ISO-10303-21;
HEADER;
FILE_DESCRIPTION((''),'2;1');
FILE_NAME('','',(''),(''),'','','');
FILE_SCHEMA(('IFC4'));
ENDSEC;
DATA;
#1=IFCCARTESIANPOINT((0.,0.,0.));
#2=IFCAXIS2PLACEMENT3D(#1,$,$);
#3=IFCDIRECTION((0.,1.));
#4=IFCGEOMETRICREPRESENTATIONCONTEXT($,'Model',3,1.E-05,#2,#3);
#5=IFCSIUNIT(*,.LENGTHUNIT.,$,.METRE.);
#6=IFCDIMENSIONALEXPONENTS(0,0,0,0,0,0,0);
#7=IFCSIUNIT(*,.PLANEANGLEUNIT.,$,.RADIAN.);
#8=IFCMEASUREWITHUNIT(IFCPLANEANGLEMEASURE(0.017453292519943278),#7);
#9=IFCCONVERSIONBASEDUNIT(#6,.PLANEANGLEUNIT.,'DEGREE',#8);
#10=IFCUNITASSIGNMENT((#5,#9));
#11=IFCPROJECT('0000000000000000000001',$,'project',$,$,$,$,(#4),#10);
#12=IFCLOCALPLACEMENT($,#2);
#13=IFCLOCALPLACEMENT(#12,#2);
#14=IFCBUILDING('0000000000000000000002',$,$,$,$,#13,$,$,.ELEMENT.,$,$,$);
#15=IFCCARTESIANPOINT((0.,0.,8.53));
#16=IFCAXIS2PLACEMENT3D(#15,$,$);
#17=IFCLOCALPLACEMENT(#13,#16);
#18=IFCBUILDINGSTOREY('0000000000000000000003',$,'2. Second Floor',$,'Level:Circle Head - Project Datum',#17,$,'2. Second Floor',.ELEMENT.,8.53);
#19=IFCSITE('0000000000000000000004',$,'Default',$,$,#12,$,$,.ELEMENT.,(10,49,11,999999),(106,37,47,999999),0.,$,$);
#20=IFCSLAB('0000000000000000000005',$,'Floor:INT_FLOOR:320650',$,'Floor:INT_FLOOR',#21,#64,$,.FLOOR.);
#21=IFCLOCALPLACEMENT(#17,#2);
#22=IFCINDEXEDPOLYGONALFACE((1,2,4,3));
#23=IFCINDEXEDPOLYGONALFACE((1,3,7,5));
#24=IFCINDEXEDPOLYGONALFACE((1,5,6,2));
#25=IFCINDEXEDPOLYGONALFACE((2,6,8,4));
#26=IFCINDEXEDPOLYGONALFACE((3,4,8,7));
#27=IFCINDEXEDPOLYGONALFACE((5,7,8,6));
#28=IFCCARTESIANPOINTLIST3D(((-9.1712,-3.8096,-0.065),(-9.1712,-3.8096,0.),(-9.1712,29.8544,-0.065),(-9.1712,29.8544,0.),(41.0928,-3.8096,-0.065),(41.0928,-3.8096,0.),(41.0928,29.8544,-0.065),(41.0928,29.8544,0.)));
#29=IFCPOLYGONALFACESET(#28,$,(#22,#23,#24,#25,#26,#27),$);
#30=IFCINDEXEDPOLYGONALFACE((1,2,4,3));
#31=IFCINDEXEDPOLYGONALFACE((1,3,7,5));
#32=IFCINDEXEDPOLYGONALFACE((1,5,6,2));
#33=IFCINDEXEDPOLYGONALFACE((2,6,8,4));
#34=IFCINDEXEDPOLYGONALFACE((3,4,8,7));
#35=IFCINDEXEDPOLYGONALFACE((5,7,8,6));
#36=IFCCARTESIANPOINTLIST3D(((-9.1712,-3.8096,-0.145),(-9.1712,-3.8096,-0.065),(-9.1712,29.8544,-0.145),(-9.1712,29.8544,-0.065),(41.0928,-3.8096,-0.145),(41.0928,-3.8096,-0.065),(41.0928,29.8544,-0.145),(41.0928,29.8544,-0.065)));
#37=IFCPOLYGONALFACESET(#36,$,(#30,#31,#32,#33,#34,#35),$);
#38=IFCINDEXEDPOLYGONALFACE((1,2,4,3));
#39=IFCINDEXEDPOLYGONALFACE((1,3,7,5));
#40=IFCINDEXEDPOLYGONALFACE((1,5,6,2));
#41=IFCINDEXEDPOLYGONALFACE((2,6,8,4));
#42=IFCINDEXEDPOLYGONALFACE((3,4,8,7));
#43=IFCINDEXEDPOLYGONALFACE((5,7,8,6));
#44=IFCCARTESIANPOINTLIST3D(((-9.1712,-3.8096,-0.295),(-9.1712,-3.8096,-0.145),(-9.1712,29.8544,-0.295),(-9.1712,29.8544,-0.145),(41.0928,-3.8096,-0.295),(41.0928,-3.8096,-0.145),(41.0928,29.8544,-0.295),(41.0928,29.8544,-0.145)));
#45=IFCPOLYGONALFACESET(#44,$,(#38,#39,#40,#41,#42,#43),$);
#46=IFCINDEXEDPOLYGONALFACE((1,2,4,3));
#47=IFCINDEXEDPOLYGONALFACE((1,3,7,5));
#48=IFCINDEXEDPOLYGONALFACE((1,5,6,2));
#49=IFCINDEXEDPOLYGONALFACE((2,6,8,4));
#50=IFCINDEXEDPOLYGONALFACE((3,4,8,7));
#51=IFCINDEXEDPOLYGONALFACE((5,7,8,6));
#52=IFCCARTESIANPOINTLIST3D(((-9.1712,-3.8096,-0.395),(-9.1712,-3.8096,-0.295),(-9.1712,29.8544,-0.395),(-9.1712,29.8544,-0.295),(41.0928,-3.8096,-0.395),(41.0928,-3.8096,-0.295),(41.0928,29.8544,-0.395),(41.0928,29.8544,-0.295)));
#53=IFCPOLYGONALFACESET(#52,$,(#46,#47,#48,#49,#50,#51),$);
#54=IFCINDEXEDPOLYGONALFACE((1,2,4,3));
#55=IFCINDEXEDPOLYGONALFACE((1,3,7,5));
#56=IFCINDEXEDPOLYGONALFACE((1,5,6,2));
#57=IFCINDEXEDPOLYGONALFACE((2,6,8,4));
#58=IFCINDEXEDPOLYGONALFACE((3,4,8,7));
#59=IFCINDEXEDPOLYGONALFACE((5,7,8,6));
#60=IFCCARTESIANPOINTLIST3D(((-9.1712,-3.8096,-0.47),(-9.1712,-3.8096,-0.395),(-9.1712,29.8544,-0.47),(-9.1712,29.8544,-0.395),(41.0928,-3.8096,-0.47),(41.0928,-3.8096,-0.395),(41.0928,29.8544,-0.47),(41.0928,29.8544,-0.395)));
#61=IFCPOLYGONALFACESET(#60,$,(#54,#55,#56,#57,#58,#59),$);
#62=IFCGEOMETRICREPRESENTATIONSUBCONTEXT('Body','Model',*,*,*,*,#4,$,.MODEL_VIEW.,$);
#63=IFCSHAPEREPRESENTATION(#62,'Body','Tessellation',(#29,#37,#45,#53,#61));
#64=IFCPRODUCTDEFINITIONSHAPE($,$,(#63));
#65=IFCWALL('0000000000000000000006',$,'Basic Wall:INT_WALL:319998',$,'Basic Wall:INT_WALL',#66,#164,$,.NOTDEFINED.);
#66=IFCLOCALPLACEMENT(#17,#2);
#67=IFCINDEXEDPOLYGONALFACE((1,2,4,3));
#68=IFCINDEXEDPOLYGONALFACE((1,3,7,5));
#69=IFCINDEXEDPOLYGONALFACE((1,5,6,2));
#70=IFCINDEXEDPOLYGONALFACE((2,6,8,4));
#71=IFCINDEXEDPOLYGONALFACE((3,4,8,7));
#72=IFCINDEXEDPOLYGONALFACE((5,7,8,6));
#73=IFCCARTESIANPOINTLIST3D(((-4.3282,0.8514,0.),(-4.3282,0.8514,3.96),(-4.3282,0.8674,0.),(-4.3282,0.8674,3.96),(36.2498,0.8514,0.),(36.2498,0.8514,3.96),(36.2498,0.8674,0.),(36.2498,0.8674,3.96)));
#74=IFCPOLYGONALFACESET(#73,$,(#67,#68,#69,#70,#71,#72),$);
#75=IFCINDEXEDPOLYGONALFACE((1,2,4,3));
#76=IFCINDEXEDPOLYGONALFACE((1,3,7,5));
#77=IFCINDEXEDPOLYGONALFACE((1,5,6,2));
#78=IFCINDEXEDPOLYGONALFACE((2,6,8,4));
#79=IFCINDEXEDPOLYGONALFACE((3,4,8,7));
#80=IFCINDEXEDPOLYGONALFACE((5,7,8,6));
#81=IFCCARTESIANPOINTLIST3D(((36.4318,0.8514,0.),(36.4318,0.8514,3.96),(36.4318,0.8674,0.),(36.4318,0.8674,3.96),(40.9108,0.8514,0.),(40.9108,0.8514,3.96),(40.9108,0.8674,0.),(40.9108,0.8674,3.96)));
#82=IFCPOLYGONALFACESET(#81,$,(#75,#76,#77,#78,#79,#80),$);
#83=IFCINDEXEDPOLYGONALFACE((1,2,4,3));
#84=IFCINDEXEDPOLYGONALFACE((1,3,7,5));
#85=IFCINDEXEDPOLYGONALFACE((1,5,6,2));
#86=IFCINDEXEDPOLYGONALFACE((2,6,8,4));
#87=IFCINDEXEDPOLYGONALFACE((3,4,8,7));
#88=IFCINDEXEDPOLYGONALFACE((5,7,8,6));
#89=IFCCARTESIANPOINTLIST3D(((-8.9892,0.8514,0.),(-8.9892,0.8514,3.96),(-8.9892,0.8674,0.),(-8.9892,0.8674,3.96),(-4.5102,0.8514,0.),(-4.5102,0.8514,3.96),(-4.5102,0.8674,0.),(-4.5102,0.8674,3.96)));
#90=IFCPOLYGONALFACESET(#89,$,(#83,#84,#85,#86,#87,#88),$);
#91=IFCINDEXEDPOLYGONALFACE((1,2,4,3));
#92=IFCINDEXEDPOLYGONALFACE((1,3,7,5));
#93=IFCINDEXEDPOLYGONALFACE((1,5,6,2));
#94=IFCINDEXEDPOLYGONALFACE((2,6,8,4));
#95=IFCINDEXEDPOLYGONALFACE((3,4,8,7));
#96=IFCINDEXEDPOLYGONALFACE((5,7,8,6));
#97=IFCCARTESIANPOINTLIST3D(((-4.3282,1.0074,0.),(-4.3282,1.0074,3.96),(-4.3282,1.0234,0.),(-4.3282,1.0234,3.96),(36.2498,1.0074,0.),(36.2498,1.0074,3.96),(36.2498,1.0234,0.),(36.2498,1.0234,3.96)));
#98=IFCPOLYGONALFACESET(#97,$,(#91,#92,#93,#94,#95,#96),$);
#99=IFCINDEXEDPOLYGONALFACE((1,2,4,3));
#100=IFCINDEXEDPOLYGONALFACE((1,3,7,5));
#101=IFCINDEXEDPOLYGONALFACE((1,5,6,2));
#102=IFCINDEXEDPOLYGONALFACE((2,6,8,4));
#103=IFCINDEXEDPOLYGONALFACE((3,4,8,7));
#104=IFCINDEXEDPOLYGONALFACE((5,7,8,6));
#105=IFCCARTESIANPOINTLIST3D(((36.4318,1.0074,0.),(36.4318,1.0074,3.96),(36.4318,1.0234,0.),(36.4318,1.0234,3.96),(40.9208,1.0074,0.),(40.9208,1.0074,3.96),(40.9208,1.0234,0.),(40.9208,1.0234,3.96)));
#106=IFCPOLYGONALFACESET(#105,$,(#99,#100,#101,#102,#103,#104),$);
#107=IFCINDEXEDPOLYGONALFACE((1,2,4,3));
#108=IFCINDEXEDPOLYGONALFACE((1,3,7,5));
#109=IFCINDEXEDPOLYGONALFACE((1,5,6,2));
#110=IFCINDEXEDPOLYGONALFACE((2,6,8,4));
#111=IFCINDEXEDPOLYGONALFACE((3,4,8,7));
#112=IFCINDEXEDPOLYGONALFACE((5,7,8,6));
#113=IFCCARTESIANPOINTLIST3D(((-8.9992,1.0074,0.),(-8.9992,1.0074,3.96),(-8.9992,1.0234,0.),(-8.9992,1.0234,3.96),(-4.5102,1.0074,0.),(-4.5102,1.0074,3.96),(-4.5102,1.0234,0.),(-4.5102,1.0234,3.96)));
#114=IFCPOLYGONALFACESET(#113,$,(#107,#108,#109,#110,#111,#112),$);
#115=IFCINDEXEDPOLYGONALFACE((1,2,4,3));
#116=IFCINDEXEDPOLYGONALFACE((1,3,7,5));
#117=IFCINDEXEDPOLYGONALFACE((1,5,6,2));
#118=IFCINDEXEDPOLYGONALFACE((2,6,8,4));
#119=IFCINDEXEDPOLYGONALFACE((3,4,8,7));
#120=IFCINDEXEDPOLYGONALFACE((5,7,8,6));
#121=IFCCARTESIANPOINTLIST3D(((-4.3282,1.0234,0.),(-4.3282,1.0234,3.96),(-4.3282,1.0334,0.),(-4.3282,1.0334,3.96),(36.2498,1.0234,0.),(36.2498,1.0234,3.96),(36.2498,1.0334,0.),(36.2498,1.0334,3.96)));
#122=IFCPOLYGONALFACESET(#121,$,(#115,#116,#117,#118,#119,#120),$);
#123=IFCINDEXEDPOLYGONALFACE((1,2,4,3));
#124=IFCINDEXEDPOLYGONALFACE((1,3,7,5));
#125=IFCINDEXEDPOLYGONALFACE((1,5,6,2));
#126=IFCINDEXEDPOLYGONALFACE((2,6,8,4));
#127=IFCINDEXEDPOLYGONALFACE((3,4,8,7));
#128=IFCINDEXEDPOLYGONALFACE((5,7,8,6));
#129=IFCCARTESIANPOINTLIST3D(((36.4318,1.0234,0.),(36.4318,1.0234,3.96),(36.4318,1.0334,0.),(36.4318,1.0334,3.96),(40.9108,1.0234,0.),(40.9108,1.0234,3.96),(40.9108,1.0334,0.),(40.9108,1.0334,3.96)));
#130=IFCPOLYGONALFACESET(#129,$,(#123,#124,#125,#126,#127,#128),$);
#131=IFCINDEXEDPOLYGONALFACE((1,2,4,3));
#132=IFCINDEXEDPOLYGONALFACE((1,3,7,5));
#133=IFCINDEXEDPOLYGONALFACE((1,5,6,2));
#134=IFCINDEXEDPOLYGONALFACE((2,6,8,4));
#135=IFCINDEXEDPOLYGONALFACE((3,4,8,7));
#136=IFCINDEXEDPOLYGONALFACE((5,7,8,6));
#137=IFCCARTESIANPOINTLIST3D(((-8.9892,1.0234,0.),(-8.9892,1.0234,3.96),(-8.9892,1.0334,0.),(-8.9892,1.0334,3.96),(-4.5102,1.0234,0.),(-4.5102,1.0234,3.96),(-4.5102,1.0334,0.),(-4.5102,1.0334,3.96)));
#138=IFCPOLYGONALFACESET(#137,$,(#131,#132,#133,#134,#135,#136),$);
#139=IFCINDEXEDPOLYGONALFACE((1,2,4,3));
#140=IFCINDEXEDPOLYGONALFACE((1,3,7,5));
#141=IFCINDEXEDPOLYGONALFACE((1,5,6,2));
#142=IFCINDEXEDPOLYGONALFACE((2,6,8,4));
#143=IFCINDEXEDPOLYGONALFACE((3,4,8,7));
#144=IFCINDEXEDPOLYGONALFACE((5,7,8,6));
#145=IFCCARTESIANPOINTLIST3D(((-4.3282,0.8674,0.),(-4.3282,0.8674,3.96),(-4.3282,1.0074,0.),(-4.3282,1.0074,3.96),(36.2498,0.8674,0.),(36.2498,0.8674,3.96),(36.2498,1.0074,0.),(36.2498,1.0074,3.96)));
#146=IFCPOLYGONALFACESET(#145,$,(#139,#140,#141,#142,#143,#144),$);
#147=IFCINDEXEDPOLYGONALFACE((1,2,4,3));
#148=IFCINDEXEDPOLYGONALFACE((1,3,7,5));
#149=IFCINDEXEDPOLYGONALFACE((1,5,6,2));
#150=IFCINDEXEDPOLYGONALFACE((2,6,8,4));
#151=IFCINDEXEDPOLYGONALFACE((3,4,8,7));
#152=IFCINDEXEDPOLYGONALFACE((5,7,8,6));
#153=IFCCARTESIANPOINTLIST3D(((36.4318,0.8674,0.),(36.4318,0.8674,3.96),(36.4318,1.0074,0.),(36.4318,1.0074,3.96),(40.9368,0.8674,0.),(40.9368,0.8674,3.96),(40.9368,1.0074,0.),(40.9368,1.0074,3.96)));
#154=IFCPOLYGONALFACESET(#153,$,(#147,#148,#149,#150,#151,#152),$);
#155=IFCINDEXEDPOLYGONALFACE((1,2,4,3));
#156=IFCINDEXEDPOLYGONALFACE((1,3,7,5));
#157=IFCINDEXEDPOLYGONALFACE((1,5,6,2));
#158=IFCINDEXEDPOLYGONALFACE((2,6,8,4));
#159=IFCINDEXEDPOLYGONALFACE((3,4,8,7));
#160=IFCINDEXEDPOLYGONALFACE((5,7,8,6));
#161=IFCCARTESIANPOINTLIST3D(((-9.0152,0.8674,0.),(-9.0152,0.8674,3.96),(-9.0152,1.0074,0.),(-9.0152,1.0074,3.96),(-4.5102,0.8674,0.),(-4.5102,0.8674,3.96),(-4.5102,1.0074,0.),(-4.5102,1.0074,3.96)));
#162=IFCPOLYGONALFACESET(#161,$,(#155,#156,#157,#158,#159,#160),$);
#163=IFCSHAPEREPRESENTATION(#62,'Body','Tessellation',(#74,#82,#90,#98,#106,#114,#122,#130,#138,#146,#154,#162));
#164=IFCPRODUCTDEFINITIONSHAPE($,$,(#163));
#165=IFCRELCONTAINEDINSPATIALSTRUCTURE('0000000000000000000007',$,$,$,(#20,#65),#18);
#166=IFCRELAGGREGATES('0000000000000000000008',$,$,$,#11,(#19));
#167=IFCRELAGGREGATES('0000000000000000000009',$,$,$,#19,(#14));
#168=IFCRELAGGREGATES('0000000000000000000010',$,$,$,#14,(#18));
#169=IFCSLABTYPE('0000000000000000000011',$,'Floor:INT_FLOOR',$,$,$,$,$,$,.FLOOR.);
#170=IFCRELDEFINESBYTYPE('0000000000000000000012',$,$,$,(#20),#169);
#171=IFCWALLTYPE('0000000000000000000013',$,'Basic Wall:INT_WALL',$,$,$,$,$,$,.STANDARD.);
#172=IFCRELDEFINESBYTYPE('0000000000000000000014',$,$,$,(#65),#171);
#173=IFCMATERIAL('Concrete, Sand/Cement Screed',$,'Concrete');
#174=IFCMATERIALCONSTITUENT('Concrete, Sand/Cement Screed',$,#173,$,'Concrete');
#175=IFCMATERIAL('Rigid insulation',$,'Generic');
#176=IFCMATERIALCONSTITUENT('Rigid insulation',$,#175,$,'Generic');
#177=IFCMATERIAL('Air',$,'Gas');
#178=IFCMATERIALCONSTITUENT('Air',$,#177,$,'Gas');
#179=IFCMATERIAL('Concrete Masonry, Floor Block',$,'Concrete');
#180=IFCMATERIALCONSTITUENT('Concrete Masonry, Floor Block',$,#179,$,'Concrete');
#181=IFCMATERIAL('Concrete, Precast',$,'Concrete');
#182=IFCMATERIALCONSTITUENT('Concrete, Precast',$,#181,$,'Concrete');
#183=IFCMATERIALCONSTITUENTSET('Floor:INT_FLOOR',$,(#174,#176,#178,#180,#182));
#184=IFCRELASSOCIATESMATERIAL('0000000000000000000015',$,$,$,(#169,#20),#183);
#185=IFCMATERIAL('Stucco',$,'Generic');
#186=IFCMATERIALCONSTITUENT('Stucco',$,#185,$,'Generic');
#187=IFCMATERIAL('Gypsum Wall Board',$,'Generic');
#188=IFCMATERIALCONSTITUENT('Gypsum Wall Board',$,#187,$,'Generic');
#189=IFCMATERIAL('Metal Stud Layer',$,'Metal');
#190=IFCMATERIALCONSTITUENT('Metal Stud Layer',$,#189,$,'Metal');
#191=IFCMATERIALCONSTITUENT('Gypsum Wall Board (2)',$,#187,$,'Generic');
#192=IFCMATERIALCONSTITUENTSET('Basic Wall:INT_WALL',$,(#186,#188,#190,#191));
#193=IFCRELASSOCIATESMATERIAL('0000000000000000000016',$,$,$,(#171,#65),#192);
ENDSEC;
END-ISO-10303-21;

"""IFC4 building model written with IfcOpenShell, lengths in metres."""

from ifc_helpers import new_model, entity, si_unit, converted_unit, direction, frame, origin, place, context, subcontext, project, spatial, indexed_curve, outline, extrude, material, constituent, constituent_set, type_object, element, save


model = new_model("IFC4")

# Units and contexts
model_context = context("Model", 3, precision=1e-05, world=origin(), true_north=direction((0.0, 1.0)))
body_context = subcontext(model_context, "Body", "Model", "MODEL_VIEW")
ifc_project = project(units=[si_unit("LENGTHUNIT", "METRE"), converted_unit("PLANEANGLEUNIT", "DEGREE", entity("IfcPlaneAngleMeasure", 0.017453292519943278), si_unit("PLANEANGLEUNIT", "RADIAN"), dimensions=[0, 0, 0, 0, 0, 0, 0])], contexts=[model_context])

# Site, building, storey
site_placement = place(None, origin())
site = spatial("IfcSite", under=ifc_project, at=site_placement, Name="Default", CompositionType="ELEMENT", RefLatitude=(10, 49, 11, 999999), RefLongitude=(106, 37, 47, 999999), RefElevation=0.0)
building_placement = place(site_placement, origin())
building = spatial("IfcBuilding", under=site, at=building_placement, CompositionType="ELEMENT")
storey_placement = place(building_placement, frame((0.0, 0.0, 8.53)))
storey = spatial("IfcBuildingStorey", under=building, at=storey_placement, Name="2. Second Floor", ObjectType="Level:Circle Head - Project Datum", LongName="2. Second Floor", CompositionType="ELEMENT", Elevation=8.53)

# Slab
ifc_material_1 = material(Name="Concrete, Sand/Cement Screed", Category="Concrete")
ifc_constituent_1 = constituent(ifc_material_1, Name="Concrete, Sand/Cement Screed", Category="Concrete")
ifc_material_2 = material(Name="Rigid insulation", Category="Generic")
ifc_constituent_2 = constituent(ifc_material_2, Name="Rigid insulation", Category="Generic")
ifc_material_3 = material(Name="Air", Category="Gas")
ifc_constituent_3 = constituent(ifc_material_3, Name="Air", Category="Gas")
ifc_material_4 = material(Name="Concrete Masonry, Floor Block", Category="Concrete")
ifc_constituent_4 = constituent(ifc_material_4, Name="Concrete Masonry, Floor Block", Category="Concrete")
ifc_material_5 = material(Name="Concrete, Precast", Category="Concrete")
ifc_constituent_5 = constituent(ifc_material_5, Name="Concrete, Precast", Category="Concrete")
ifc_constituent_set_1 = constituent_set(constituents=[ifc_constituent_1, ifc_constituent_2, ifc_constituent_3, ifc_constituent_4, ifc_constituent_5], Name="Floor:INT_FLOOR")
slab_type = type_object("IfcSlabType", Name="Floor:INT_FLOOR", PredefinedType="FLOOR", material=ifc_constituent_set_1)
slab_placement = place(storey_placement, origin())
element("IfcSlab", 1, at=slab_placement, inside=storey, type_object=slab_type, material=ifc_constituent_set_1, Name="Floor:INT_FLOOR:320650", ObjectType="Floor:INT_FLOOR", PredefinedType="FLOOR", context=body_context, shape_type="SweptSolid", body=[
    extrude(outline(indexed_curve([(-25.132, -16.832), (25.132, -16.832), (25.132, 16.832), (-25.132, 16.832), (-25.132, -16.832)], self_intersect=False)), frame((15.9608, 13.0224, -0.065), z_axis=(0.0, 0.0, 1.0), x_axis=(-1.0, 0.0, 0.0)), (0.0, 0.0, 1.0), 0.065),
    extrude(outline(indexed_curve([(-25.132, -16.832), (25.132, -16.832), (25.132, 16.832), (-25.132, 16.832), (-25.132, -16.832)], self_intersect=False)), frame((15.9608, 13.0224, -0.145), z_axis=(0.0, 0.0, 1.0), x_axis=(-1.0, 0.0, 0.0)), (0.0, 0.0, 1.0), 0.08),
    extrude(outline(indexed_curve([(-25.132, -16.832), (25.132, -16.832), (25.132, 16.832), (-25.132, 16.832), (-25.132, -16.832)], self_intersect=False)), frame((15.9608, 13.0224, -0.295), z_axis=(0.0, 0.0, 1.0), x_axis=(-1.0, 0.0, 0.0)), (0.0, 0.0, 1.0), 0.15),
    extrude(outline(indexed_curve([(-25.132, -16.832), (25.132, -16.832), (25.132, 16.832), (-25.132, 16.832), (-25.132, -16.832)], self_intersect=False)), frame((15.9608, 13.0224, -0.395), z_axis=(0.0, 0.0, 1.0), x_axis=(-1.0, 0.0, 0.0)), (0.0, 0.0, 1.0), 0.1),
    extrude(outline(indexed_curve([(-25.132, -16.832), (25.132, -16.832), (25.132, 16.832), (-25.132, 16.832), (-25.132, -16.832)], self_intersect=False)), frame((15.9608, 13.0224, -0.47), z_axis=(0.0, 0.0, 1.0), x_axis=(-1.0, 0.0, 0.0)), (0.0, 0.0, 1.0), 0.075),
])

# Wall
ifc_material_6 = material(Name="Stucco", Category="Generic")
ifc_constituent_6 = constituent(ifc_material_6, Name="Stucco", Category="Generic")
ifc_material_7 = material(Name="Gypsum Wall Board", Category="Generic")
ifc_constituent_7 = constituent(ifc_material_7, Name="Gypsum Wall Board", Category="Generic")
ifc_material_8 = material(Name="Metal Stud Layer", Category="Metal")
ifc_constituent_8 = constituent(ifc_material_8, Name="Metal Stud Layer", Category="Metal")
ifc_constituent_9 = constituent(ifc_material_7, Name="Gypsum Wall Board (2)", Category="Generic")
ifc_constituent_set_2 = constituent_set(constituents=[ifc_constituent_6, ifc_constituent_7, ifc_constituent_8, ifc_constituent_9], Name="Basic Wall:INT_WALL")
wall_type_1 = type_object("IfcWallType", Name="Basic Wall:INT_WALL", PredefinedType="STANDARD", material=ifc_constituent_set_2)
wall_1_placement = place(storey_placement, frame((-8.9892, 0.9424, 0.0)))
element("IfcWall", 2, at=wall_1_placement, inside=storey, type_object=wall_type_1, material=ifc_constituent_set_2, Name="Basic Wall:INT_WALL:319998", ObjectType="Basic Wall:INT_WALL", PredefinedType="NOTDEFINED", context=body_context, shape_type="SweptSolid", body=[
    extrude(outline(indexed_curve([(-0.008, -20.289), (0.008, -20.289), (0.008, 20.289), (-0.008, 20.289), (-0.008, -20.289)], self_intersect=False)), frame((24.95, -0.083, 0.0), z_axis=(0.0, 0.0, 1.0), x_axis=(0.0, 1.0, 0.0)), (0.0, 0.0, 1.0), 3.96),
    extrude(outline(indexed_curve([(-0.008, -2.2395), (0.008, -2.2395), (0.008, 2.2395), (-0.008, 2.2395), (-0.008, -2.2395)], self_intersect=False)), frame((47.6605, -0.083, 0.0), z_axis=(0.0, 0.0, 1.0), x_axis=(0.0, 1.0, 0.0)), (0.0, 0.0, 1.0), 3.96),
    extrude(outline(indexed_curve([(-0.008, -2.2395), (0.008, -2.2395), (0.008, 2.2395), (-0.008, 2.2395), (-0.008, -2.2395)], self_intersect=False)), frame((2.2395, -0.083, 0.0), z_axis=(0.0, 0.0, 1.0), x_axis=(0.0, 1.0, 0.0)), (0.0, 0.0, 1.0), 3.96),
    extrude(outline(indexed_curve([(-20.289, -0.008), (20.289, -0.008), (20.289, 0.008), (-20.289, 0.008), (-20.289, -0.008)], self_intersect=False)), frame((24.95, 0.073, 0.0)), (0.0, 0.0, 1.0), 3.96),
    extrude(outline(indexed_curve([(-2.2445, -0.008), (2.2445, -0.008), (2.2445, 0.008), (-2.2445, 0.008), (-2.2445, -0.008)], self_intersect=False)), frame((47.6655, 0.073, 0.0), z_axis=(0.0, 0.0, 1.0), x_axis=(-1.0, 0.0, 0.0)), (0.0, 0.0, 1.0), 3.96),
    extrude(outline(indexed_curve([(-2.2445, -0.008), (2.2445, -0.008), (2.2445, 0.008), (-2.2445, 0.008), (-2.2445, -0.008)], self_intersect=False)), frame((2.2345, 0.073, 0.0)), (0.0, 0.0, 1.0), 3.96),
    extrude(outline(indexed_curve([(-0.005, -20.289), (0.005, -20.289), (0.005, 20.289), (-0.005, 20.289), (-0.005, -20.289)], self_intersect=False)), frame((24.95, 0.086, 0.0), z_axis=(0.0, 0.0, 1.0), x_axis=(0.0, -1.0, 0.0)), (0.0, 0.0, 1.0), 3.96),
    extrude(outline(indexed_curve([(-0.005, -2.2395), (0.005, -2.2395), (0.005, 2.2395), (-0.005, 2.2395), (-0.005, -2.2395)], self_intersect=False)), frame((47.6605, 0.086, 0.0), z_axis=(0.0, 0.0, 1.0), x_axis=(0.0, -1.0, 0.0)), (0.0, 0.0, 1.0), 3.96),
    extrude(outline(indexed_curve([(-0.005, -2.2395), (0.005, -2.2395), (0.005, 2.2395), (-0.005, 2.2395), (-0.005, -2.2395)], self_intersect=False)), frame((2.2395, 0.086, 0.0), z_axis=(0.0, 0.0, 1.0), x_axis=(0.0, -1.0, 0.0)), (0.0, 0.0, 1.0), 3.96),
    extrude(outline(indexed_curve([(-20.289, -0.07), (20.289, -0.07), (20.289, 0.07), (-20.289, 0.07), (-20.289, -0.07)], self_intersect=False)), frame((24.95, -0.005, 0.0)), (0.0, 0.0, 1.0), 3.96),
    extrude(outline(indexed_curve([(-2.2525, -0.07), (2.2525, -0.07), (2.2525, 0.07), (-2.2525, 0.07), (-2.2525, -0.07)], self_intersect=False)), frame((47.6735, -0.005, 0.0), z_axis=(0.0, 0.0, 1.0), x_axis=(-1.0, 0.0, 0.0)), (0.0, 0.0, 1.0), 3.96),
    extrude(outline(indexed_curve([(-2.2525, -0.07), (2.2525, -0.07), (2.2525, 0.07), (-2.2525, 0.07), (-2.2525, -0.07)], self_intersect=False)), frame((2.2265, -0.005, 0.0)), (0.0, 0.0, 1.0), 3.96),
])

save(model, "model.ifc")
